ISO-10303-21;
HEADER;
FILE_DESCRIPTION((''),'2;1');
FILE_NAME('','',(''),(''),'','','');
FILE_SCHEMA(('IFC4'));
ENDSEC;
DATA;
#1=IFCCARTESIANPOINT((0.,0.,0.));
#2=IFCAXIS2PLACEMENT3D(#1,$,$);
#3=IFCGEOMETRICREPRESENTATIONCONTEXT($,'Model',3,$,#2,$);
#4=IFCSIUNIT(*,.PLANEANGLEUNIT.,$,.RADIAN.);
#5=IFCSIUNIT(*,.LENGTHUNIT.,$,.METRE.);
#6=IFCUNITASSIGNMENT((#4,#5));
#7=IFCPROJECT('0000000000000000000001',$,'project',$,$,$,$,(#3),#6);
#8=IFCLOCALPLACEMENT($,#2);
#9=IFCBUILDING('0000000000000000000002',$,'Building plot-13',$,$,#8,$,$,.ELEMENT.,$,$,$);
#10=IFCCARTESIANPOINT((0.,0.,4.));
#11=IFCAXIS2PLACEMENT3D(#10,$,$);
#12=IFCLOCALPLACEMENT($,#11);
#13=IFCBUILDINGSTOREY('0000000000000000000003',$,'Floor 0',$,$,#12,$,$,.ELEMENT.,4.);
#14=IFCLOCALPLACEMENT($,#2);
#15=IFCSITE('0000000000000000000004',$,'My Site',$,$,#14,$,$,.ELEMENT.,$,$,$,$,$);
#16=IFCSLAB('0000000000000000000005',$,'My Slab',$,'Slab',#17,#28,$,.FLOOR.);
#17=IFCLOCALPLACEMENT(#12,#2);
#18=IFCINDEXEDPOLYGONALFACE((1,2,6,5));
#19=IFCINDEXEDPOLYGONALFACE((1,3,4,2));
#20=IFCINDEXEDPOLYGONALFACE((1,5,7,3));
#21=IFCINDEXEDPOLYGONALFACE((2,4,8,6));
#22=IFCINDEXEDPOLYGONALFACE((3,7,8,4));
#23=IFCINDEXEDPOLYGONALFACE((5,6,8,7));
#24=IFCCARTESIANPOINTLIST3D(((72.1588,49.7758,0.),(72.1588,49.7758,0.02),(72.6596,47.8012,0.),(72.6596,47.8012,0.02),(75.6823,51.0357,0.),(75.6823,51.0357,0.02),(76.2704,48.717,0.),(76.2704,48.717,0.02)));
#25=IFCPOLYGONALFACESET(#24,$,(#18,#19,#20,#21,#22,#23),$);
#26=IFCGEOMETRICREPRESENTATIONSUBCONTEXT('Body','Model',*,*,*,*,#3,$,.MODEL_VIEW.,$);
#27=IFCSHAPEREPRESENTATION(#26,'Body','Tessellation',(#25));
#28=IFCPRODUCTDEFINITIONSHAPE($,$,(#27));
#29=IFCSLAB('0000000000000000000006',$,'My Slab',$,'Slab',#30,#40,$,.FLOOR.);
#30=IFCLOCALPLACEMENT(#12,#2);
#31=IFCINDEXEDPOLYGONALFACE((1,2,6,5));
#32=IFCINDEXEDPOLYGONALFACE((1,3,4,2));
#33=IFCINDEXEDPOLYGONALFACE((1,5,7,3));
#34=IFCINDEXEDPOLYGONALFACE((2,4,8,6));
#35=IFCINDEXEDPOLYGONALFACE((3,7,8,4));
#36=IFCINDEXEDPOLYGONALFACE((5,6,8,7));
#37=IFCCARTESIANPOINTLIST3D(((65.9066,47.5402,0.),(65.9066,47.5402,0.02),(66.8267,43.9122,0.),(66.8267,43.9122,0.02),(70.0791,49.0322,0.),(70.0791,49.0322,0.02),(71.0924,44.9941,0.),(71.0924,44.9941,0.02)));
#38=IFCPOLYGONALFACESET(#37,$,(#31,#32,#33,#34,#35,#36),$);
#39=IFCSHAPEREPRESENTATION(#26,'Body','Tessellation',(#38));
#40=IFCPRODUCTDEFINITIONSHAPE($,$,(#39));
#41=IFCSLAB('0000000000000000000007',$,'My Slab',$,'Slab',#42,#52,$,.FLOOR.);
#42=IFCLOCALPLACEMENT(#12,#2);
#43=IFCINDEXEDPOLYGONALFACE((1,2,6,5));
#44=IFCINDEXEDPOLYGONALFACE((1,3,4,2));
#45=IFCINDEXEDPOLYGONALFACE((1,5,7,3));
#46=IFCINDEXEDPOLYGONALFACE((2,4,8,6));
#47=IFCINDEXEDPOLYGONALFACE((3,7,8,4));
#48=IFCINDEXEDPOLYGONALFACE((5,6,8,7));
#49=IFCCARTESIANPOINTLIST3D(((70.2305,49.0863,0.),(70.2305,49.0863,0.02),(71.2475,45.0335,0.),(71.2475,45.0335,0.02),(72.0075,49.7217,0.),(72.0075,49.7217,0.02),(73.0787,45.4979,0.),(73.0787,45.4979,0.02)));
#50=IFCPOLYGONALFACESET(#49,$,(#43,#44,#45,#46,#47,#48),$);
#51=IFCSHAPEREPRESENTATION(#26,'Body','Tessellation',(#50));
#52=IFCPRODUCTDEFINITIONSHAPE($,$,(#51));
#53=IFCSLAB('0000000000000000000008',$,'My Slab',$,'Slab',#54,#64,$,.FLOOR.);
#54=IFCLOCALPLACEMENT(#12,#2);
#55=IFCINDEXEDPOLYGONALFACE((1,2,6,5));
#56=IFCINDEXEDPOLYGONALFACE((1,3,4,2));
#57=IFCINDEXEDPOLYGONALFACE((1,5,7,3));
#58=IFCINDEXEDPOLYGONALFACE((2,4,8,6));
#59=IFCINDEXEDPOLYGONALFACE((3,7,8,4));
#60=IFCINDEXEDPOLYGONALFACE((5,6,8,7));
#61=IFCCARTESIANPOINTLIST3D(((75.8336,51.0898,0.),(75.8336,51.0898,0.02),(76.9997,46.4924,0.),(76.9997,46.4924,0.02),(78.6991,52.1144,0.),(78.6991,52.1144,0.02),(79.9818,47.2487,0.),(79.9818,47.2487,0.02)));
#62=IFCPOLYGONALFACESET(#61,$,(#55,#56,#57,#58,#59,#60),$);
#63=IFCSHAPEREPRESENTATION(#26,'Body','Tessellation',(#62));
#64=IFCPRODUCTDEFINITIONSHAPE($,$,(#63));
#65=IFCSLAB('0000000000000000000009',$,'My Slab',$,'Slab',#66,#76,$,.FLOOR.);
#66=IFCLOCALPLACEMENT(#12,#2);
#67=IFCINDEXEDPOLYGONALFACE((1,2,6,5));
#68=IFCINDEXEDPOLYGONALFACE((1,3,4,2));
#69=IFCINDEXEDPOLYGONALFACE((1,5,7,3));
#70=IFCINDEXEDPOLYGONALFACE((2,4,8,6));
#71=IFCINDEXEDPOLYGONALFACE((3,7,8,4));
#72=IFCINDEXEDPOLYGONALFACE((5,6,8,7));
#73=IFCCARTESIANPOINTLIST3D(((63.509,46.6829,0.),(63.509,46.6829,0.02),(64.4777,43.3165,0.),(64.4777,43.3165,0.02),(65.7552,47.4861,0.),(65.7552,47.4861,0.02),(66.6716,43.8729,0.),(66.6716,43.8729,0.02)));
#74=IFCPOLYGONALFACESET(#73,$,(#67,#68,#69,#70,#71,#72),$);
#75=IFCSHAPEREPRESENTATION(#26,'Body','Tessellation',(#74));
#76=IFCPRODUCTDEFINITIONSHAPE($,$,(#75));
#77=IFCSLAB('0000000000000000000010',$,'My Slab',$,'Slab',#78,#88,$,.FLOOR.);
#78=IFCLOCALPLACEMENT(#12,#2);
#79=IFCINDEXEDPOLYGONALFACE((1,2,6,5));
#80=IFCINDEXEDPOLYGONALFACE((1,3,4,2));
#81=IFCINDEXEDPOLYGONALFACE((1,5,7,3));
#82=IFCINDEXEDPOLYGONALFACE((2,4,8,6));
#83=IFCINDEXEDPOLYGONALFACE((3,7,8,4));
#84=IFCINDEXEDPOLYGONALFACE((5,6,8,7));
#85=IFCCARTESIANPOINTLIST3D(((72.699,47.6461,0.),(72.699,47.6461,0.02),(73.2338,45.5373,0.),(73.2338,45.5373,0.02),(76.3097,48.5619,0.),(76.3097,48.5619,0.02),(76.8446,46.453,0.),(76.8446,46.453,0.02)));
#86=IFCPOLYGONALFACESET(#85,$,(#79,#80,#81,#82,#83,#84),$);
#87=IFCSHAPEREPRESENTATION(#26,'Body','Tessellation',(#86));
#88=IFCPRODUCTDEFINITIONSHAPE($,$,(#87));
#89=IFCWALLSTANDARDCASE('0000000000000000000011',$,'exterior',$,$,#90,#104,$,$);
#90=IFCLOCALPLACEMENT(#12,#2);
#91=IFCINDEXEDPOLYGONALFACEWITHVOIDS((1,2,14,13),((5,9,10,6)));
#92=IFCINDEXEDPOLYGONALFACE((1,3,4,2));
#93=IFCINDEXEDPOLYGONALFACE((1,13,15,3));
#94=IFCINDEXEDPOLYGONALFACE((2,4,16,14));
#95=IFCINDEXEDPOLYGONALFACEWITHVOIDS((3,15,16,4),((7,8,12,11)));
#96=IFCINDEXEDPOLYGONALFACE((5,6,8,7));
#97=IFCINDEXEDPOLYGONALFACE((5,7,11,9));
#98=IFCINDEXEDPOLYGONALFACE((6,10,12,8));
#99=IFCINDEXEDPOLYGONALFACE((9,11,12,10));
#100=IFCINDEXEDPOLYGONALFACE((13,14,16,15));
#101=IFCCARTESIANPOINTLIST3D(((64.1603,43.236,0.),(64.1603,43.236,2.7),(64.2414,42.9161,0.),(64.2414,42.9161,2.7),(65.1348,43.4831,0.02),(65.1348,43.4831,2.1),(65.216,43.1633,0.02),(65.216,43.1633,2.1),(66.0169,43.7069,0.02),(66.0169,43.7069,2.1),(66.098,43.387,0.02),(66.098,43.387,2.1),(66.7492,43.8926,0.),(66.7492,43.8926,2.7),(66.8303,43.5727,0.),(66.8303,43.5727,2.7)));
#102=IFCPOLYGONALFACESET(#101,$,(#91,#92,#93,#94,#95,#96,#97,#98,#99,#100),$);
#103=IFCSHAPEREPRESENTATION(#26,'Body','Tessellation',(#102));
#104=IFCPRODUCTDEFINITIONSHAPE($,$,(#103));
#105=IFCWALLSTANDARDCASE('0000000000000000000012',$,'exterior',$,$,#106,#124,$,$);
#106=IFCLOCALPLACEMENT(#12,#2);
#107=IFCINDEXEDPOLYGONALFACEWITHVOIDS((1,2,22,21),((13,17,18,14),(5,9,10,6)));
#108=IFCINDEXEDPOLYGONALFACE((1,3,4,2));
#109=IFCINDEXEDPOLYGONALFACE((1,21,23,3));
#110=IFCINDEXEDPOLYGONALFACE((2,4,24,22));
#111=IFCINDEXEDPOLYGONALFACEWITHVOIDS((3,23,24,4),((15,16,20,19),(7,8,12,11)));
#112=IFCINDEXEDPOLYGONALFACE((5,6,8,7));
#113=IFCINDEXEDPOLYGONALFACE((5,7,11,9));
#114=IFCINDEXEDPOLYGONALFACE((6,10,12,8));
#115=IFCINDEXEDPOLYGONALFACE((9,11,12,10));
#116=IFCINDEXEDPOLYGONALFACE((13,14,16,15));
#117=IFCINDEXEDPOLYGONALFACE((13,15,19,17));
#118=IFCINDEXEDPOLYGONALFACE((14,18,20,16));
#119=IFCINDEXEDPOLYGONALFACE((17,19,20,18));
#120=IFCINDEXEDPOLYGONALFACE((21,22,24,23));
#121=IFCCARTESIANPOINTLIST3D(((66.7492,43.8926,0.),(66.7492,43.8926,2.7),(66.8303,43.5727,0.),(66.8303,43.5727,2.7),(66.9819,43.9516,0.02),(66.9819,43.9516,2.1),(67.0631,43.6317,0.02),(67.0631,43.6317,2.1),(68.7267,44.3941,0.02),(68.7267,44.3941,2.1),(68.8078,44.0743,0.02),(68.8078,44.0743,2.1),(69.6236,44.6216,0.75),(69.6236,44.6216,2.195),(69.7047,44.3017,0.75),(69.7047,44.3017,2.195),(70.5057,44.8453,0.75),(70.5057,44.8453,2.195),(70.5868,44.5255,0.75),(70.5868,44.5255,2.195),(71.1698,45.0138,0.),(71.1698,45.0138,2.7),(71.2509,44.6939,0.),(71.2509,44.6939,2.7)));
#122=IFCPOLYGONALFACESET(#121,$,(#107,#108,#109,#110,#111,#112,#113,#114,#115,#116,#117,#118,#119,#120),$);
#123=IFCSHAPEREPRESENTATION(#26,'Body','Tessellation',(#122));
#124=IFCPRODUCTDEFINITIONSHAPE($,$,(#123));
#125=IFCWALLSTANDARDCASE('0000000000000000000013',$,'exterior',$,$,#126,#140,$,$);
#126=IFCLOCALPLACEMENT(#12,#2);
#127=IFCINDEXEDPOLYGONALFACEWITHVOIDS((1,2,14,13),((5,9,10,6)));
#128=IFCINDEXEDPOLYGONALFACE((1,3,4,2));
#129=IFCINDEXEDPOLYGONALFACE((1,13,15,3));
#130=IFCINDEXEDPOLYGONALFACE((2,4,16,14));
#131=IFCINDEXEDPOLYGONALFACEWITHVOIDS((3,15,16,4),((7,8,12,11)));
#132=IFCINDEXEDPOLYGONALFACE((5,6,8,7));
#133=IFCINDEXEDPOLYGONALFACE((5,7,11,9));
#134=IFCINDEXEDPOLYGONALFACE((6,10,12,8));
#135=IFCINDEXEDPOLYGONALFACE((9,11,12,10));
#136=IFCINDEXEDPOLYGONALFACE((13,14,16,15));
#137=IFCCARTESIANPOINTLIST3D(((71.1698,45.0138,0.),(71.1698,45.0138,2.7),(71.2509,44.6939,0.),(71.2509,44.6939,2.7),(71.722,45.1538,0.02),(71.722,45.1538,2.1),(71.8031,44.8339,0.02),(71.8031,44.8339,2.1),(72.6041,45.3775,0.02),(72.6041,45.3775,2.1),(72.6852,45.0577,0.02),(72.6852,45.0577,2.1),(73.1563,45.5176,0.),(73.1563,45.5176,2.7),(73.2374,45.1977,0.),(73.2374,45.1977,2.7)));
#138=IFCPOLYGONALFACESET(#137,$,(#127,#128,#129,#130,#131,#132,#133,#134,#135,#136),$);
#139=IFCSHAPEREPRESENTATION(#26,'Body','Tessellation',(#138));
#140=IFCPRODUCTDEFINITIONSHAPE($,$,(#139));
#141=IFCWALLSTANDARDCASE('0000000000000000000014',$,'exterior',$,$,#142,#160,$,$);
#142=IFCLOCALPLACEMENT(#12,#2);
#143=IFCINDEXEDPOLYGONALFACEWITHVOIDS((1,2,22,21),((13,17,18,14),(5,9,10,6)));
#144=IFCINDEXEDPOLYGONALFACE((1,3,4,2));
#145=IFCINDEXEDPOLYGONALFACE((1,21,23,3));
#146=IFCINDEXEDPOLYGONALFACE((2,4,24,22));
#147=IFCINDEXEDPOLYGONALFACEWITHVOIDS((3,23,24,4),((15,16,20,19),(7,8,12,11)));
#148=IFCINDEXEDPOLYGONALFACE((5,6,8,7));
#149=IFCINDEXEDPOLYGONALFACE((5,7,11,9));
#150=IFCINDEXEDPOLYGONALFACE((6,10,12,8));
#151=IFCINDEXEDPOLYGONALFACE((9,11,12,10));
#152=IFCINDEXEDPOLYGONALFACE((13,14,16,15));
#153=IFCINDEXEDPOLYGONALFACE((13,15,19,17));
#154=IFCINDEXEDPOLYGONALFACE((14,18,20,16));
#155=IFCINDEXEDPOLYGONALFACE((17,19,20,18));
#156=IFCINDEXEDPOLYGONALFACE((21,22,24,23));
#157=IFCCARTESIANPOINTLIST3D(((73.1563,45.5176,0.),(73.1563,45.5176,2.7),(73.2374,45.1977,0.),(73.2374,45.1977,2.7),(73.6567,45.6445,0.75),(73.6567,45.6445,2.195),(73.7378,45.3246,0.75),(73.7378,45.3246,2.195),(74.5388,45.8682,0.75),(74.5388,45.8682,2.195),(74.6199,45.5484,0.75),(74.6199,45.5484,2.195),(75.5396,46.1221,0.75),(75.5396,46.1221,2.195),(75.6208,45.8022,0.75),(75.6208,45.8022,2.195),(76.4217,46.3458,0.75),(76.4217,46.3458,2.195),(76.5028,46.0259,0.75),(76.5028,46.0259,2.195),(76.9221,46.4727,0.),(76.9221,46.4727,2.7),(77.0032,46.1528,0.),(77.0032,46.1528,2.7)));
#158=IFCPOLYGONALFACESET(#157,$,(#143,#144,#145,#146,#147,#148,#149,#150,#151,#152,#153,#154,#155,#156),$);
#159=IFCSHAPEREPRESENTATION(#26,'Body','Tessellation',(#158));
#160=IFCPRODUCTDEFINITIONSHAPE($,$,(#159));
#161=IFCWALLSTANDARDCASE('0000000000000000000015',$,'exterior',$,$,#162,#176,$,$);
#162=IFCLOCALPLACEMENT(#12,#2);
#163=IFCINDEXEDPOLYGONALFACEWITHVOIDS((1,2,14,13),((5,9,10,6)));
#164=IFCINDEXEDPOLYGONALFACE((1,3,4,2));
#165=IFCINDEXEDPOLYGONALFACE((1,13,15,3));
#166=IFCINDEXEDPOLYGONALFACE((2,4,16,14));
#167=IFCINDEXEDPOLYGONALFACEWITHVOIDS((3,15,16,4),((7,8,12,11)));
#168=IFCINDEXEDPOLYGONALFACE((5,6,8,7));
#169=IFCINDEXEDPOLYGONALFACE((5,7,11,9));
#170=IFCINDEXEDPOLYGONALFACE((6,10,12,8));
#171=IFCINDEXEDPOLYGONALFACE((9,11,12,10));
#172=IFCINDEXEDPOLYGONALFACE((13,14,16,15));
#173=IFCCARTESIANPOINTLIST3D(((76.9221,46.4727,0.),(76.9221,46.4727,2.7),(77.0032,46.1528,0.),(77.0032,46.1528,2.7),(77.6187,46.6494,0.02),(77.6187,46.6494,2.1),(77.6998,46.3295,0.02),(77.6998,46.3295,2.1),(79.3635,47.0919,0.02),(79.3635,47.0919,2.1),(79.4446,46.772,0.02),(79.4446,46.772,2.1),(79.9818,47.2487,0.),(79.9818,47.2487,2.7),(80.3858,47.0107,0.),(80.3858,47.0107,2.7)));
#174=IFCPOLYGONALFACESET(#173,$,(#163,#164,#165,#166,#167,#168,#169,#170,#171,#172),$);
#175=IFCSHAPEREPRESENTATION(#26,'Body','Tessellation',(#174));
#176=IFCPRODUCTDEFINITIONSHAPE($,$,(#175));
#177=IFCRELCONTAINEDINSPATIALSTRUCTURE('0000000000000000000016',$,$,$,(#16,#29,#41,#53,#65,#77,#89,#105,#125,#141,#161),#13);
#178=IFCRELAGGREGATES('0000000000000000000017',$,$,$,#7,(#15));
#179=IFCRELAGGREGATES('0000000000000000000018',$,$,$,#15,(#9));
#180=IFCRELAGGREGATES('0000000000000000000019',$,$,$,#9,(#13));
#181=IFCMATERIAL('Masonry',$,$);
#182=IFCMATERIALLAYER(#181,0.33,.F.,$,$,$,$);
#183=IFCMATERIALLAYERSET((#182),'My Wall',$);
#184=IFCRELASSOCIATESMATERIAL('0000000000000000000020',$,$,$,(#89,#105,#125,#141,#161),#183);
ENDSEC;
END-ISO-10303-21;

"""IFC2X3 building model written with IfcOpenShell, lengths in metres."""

from ifc_helpers import new_model, si_unit, frame, origin, place, context, subcontext, project, spatial, polyline, outline, extrude, material, layer, layer_set, layer_usage, element, save


model = new_model("IFC2X3")

# Units and contexts
model_context = context("Model", 3, world=origin())
body_context = subcontext(model_context, "Body", "Model", "MODEL_VIEW")
ifc_project = project(units=[si_unit("PLANEANGLEUNIT", "RADIAN"), si_unit("LENGTHUNIT", "METRE")], contexts=[model_context])

# Site, building, storey
site_placement = place(None, origin())
site = spatial("IfcSite", under=ifc_project, at=site_placement, Name="My Site", CompositionType="ELEMENT")
building_placement = place(None, origin())
building = spatial("IfcBuilding", under=site, at=building_placement, Name="Building plot-13", CompositionType="ELEMENT")
storey_placement = place(None, frame((0.0, 0.0, 4.0)))
storey = spatial("IfcBuildingStorey", under=building, at=storey_placement, Name="Floor 0", CompositionType="ELEMENT", Elevation=4.0)

# Slabs
slab_1_placement = place(storey_placement, origin())
element("IfcSlab", 1, at=slab_1_placement, inside=storey, Name="My Slab", ObjectType="Slab", PredefinedType="FLOOR", context=body_context, shape_type="SweptSolid", body=[
    extrude(outline(polyline([(72.1588, 49.7758), (72.6596, 47.8012), (76.2704, 48.717), (75.6823, 51.0357), (72.1588, 49.7758)])), origin(), (0.0, 0.0, 1.0), 0.02),
])
slab_2_placement = place(storey_placement, origin())
element("IfcSlab", 2, at=slab_2_placement, inside=storey, Name="My Slab", ObjectType="Slab", PredefinedType="FLOOR", context=body_context, shape_type="SweptSolid", body=[
    extrude(outline(polyline([(66.8267, 43.9122), (71.0924, 44.9941), (70.0791, 49.0322), (65.9066, 47.5402), (66.8267, 43.9122)])), origin(), (0.0, 0.0, 1.0), 0.02),
])
slab_3_placement = place(storey_placement, origin())
element("IfcSlab", 3, at=slab_3_placement, inside=storey, Name="My Slab", ObjectType="Slab", PredefinedType="FLOOR", context=body_context, shape_type="SweptSolid", body=[
    extrude(outline(polyline([(70.2305, 49.0863), (71.2475, 45.0335), (73.0787, 45.4979), (72.0075, 49.7217), (70.2305, 49.0863)])), origin(), (0.0, 0.0, 1.0), 0.02),
])
slab_4_placement = place(storey_placement, origin())
element("IfcSlab", 4, at=slab_4_placement, inside=storey, Name="My Slab", ObjectType="Slab", PredefinedType="FLOOR", context=body_context, shape_type="SweptSolid", body=[
    extrude(outline(polyline([(76.9997, 46.4924), (79.9818, 47.2487), (78.6991, 52.1144), (75.8336, 51.0898), (76.9997, 46.4924)])), origin(), (0.0, 0.0, 1.0), 0.02),
])
slab_5_placement = place(storey_placement, origin())
element("IfcSlab", 5, at=slab_5_placement, inside=storey, Name="My Slab", ObjectType="Slab", PredefinedType="FLOOR", context=body_context, shape_type="SweptSolid", body=[
    extrude(outline(polyline([(65.7552, 47.4861), (63.509, 46.6829), (64.4777, 43.3165), (66.6716, 43.8729), (65.7552, 47.4861)])), origin(), (0.0, 0.0, 1.0), 0.02),
])
slab_6_placement = place(storey_placement, origin())
element("IfcSlab", 6, at=slab_6_placement, inside=storey, Name="My Slab", ObjectType="Slab", PredefinedType="FLOOR", context=body_context, shape_type="SweptSolid", body=[
    extrude(outline(polyline([(72.699, 47.6461), (73.2338, 45.5373), (76.8446, 46.453), (76.3097, 48.5619), (72.699, 47.6461)])), origin(), (0.0, 0.0, 1.0), 0.02),
])

# Wall, opening
ifc_material = material(Name="Masonry")
ifc_layer = layer(ifc_material, 0.33, ventilated=False)
ifc_layer_set = layer_set([ifc_layer], Name="My Wall")
ifc_layer_usage = layer_usage(ifc_layer_set, "AXIS2", "NEGATIVE", 0.08)
wall_1_placement = place(storey_placement, origin())
wall_1 = element("IfcWallStandardCase", 7, at=wall_1_placement, inside=storey, material=ifc_layer_usage, Name="exterior", context=body_context, shape_type="SweptSolid", body=[
    extrude(outline(polyline([(64.1603, 43.236), (64.2414, 42.9161), (66.8303, 43.5727), (66.7492, 43.8926), (64.1603, 43.236)])), origin(), (0.0, 0.0, 1.0), 2.7),
])
opening_1_placement = place(storey_placement, frame((0.0, 0.0, 0.02)))
element("IfcOpeningElement", 8, at=opening_1_placement, cuts=wall_1, ObjectType="Opening", context=body_context, shape_type="SweptSolid", body=[
    extrude(outline(polyline([(65.216, 43.1633), (66.098, 43.387), (66.0169, 43.7069), (65.1348, 43.4831), (65.216, 43.1633)])), origin(), (0.0, 0.0, 1.0), 2.08),
])

# Wall, openings
wall_2_placement = place(storey_placement, origin())
wall_2 = element("IfcWallStandardCase", 9, at=wall_2_placement, inside=storey, material=ifc_layer_usage, Name="exterior", context=body_context, shape_type="SweptSolid", body=[
    extrude(outline(polyline([(66.7492, 43.8926), (66.8303, 43.5727), (71.2509, 44.6939), (71.1698, 45.0138), (66.7492, 43.8926)])), origin(), (0.0, 0.0, 1.0), 2.7),
])
opening_2_placement = place(storey_placement, frame((0.0, 0.0, 0.02)))
element("IfcOpeningElement", 10, at=opening_2_placement, cuts=wall_2, ObjectType="Opening", context=body_context, shape_type="SweptSolid", body=[
    extrude(outline(polyline([(67.0631, 43.6317), (68.8078, 44.0743), (68.7267, 44.3941), (66.9819, 43.9516), (67.0631, 43.6317)])), origin(), (0.0, 0.0, 1.0), 2.08),
])
opening_3_placement = place(storey_placement, frame((0.0, 0.0, 0.75)))
element("IfcOpeningElement", 11, at=opening_3_placement, cuts=wall_2, ObjectType="Opening", context=body_context, shape_type="SweptSolid", body=[
    extrude(outline(polyline([(69.7047, 44.3017), (70.5868, 44.5255), (70.5057, 44.8453), (69.6236, 44.6216), (69.7047, 44.3017)])), origin(), (0.0, 0.0, 1.0), 1.445),
])

# Wall, opening
wall_3_placement = place(storey_placement, origin())
wall_3 = element("IfcWallStandardCase", 12, at=wall_3_placement, inside=storey, material=ifc_layer_usage, Name="exterior", context=body_context, shape_type="SweptSolid", body=[
    extrude(outline(polyline([(71.1698, 45.0138), (71.2509, 44.6939), (73.2374, 45.1977), (73.1563, 45.5176), (71.1698, 45.0138)])), origin(), (0.0, 0.0, 1.0), 2.7),
])
opening_4_placement = place(storey_placement, frame((0.0, 0.0, 0.02)))
element("IfcOpeningElement", 13, at=opening_4_placement, cuts=wall_3, ObjectType="Opening", context=body_context, shape_type="SweptSolid", body=[
    extrude(outline(polyline([(71.8031, 44.8339), (72.6852, 45.0577), (72.6041, 45.3775), (71.722, 45.1538), (71.8031, 44.8339)])), origin(), (0.0, 0.0, 1.0), 2.08),
])

# Wall, openings
wall_4_placement = place(storey_placement, origin())
wall_4 = element("IfcWallStandardCase", 14, at=wall_4_placement, inside=storey, material=ifc_layer_usage, Name="exterior", context=body_context, shape_type="SweptSolid", body=[
    extrude(outline(polyline([(73.1563, 45.5176), (73.2374, 45.1977), (77.0032, 46.1528), (76.9221, 46.4727), (73.1563, 45.5176)])), origin(), (0.0, 0.0, 1.0), 2.7),
])
opening_5_placement = place(storey_placement, frame((0.0, 0.0, 0.75)))
element("IfcOpeningElement", 15, at=opening_5_placement, cuts=wall_4, ObjectType="Opening", context=body_context, shape_type="SweptSolid", body=[
    extrude(outline(polyline([(73.7378, 45.3246), (74.6199, 45.5484), (74.5388, 45.8682), (73.6567, 45.6445), (73.7378, 45.3246)])), origin(), (0.0, 0.0, 1.0), 1.445),
])
opening_6_placement = place(storey_placement, frame((0.0, 0.0, 0.75)))
element("IfcOpeningElement", 16, at=opening_6_placement, cuts=wall_4, ObjectType="Opening", context=body_context, shape_type="SweptSolid", body=[
    extrude(outline(polyline([(75.6208, 45.8022), (76.5028, 46.0259), (76.4217, 46.3458), (75.5396, 46.1221), (75.6208, 45.8022)])), origin(), (0.0, 0.0, 1.0), 1.445),
])

# Wall, opening
wall_5_placement = place(storey_placement, origin())
wall_5 = element("IfcWallStandardCase", 17, at=wall_5_placement, inside=storey, material=ifc_layer_usage, Name="exterior", context=body_context, shape_type="SweptSolid", body=[
    extrude(outline(polyline([(76.9221, 46.4727), (77.0032, 46.1528), (80.3858, 47.0107), (79.9818, 47.2487), (76.9221, 46.4727)])), origin(), (0.0, 0.0, 1.0), 2.7),
])
opening_7_placement = place(storey_placement, frame((0.0, 0.0, 0.02)))
element("IfcOpeningElement", 18, at=opening_7_placement, cuts=wall_5, ObjectType="Opening", context=body_context, shape_type="SweptSolid", body=[
    extrude(outline(polyline([(77.6998, 46.3295), (79.4446, 46.772), (79.3635, 47.0919), (77.6187, 46.6494), (77.6998, 46.3295)])), origin(), (0.0, 0.0, 1.0), 2.08),
])

save(model, "model.ifc")
